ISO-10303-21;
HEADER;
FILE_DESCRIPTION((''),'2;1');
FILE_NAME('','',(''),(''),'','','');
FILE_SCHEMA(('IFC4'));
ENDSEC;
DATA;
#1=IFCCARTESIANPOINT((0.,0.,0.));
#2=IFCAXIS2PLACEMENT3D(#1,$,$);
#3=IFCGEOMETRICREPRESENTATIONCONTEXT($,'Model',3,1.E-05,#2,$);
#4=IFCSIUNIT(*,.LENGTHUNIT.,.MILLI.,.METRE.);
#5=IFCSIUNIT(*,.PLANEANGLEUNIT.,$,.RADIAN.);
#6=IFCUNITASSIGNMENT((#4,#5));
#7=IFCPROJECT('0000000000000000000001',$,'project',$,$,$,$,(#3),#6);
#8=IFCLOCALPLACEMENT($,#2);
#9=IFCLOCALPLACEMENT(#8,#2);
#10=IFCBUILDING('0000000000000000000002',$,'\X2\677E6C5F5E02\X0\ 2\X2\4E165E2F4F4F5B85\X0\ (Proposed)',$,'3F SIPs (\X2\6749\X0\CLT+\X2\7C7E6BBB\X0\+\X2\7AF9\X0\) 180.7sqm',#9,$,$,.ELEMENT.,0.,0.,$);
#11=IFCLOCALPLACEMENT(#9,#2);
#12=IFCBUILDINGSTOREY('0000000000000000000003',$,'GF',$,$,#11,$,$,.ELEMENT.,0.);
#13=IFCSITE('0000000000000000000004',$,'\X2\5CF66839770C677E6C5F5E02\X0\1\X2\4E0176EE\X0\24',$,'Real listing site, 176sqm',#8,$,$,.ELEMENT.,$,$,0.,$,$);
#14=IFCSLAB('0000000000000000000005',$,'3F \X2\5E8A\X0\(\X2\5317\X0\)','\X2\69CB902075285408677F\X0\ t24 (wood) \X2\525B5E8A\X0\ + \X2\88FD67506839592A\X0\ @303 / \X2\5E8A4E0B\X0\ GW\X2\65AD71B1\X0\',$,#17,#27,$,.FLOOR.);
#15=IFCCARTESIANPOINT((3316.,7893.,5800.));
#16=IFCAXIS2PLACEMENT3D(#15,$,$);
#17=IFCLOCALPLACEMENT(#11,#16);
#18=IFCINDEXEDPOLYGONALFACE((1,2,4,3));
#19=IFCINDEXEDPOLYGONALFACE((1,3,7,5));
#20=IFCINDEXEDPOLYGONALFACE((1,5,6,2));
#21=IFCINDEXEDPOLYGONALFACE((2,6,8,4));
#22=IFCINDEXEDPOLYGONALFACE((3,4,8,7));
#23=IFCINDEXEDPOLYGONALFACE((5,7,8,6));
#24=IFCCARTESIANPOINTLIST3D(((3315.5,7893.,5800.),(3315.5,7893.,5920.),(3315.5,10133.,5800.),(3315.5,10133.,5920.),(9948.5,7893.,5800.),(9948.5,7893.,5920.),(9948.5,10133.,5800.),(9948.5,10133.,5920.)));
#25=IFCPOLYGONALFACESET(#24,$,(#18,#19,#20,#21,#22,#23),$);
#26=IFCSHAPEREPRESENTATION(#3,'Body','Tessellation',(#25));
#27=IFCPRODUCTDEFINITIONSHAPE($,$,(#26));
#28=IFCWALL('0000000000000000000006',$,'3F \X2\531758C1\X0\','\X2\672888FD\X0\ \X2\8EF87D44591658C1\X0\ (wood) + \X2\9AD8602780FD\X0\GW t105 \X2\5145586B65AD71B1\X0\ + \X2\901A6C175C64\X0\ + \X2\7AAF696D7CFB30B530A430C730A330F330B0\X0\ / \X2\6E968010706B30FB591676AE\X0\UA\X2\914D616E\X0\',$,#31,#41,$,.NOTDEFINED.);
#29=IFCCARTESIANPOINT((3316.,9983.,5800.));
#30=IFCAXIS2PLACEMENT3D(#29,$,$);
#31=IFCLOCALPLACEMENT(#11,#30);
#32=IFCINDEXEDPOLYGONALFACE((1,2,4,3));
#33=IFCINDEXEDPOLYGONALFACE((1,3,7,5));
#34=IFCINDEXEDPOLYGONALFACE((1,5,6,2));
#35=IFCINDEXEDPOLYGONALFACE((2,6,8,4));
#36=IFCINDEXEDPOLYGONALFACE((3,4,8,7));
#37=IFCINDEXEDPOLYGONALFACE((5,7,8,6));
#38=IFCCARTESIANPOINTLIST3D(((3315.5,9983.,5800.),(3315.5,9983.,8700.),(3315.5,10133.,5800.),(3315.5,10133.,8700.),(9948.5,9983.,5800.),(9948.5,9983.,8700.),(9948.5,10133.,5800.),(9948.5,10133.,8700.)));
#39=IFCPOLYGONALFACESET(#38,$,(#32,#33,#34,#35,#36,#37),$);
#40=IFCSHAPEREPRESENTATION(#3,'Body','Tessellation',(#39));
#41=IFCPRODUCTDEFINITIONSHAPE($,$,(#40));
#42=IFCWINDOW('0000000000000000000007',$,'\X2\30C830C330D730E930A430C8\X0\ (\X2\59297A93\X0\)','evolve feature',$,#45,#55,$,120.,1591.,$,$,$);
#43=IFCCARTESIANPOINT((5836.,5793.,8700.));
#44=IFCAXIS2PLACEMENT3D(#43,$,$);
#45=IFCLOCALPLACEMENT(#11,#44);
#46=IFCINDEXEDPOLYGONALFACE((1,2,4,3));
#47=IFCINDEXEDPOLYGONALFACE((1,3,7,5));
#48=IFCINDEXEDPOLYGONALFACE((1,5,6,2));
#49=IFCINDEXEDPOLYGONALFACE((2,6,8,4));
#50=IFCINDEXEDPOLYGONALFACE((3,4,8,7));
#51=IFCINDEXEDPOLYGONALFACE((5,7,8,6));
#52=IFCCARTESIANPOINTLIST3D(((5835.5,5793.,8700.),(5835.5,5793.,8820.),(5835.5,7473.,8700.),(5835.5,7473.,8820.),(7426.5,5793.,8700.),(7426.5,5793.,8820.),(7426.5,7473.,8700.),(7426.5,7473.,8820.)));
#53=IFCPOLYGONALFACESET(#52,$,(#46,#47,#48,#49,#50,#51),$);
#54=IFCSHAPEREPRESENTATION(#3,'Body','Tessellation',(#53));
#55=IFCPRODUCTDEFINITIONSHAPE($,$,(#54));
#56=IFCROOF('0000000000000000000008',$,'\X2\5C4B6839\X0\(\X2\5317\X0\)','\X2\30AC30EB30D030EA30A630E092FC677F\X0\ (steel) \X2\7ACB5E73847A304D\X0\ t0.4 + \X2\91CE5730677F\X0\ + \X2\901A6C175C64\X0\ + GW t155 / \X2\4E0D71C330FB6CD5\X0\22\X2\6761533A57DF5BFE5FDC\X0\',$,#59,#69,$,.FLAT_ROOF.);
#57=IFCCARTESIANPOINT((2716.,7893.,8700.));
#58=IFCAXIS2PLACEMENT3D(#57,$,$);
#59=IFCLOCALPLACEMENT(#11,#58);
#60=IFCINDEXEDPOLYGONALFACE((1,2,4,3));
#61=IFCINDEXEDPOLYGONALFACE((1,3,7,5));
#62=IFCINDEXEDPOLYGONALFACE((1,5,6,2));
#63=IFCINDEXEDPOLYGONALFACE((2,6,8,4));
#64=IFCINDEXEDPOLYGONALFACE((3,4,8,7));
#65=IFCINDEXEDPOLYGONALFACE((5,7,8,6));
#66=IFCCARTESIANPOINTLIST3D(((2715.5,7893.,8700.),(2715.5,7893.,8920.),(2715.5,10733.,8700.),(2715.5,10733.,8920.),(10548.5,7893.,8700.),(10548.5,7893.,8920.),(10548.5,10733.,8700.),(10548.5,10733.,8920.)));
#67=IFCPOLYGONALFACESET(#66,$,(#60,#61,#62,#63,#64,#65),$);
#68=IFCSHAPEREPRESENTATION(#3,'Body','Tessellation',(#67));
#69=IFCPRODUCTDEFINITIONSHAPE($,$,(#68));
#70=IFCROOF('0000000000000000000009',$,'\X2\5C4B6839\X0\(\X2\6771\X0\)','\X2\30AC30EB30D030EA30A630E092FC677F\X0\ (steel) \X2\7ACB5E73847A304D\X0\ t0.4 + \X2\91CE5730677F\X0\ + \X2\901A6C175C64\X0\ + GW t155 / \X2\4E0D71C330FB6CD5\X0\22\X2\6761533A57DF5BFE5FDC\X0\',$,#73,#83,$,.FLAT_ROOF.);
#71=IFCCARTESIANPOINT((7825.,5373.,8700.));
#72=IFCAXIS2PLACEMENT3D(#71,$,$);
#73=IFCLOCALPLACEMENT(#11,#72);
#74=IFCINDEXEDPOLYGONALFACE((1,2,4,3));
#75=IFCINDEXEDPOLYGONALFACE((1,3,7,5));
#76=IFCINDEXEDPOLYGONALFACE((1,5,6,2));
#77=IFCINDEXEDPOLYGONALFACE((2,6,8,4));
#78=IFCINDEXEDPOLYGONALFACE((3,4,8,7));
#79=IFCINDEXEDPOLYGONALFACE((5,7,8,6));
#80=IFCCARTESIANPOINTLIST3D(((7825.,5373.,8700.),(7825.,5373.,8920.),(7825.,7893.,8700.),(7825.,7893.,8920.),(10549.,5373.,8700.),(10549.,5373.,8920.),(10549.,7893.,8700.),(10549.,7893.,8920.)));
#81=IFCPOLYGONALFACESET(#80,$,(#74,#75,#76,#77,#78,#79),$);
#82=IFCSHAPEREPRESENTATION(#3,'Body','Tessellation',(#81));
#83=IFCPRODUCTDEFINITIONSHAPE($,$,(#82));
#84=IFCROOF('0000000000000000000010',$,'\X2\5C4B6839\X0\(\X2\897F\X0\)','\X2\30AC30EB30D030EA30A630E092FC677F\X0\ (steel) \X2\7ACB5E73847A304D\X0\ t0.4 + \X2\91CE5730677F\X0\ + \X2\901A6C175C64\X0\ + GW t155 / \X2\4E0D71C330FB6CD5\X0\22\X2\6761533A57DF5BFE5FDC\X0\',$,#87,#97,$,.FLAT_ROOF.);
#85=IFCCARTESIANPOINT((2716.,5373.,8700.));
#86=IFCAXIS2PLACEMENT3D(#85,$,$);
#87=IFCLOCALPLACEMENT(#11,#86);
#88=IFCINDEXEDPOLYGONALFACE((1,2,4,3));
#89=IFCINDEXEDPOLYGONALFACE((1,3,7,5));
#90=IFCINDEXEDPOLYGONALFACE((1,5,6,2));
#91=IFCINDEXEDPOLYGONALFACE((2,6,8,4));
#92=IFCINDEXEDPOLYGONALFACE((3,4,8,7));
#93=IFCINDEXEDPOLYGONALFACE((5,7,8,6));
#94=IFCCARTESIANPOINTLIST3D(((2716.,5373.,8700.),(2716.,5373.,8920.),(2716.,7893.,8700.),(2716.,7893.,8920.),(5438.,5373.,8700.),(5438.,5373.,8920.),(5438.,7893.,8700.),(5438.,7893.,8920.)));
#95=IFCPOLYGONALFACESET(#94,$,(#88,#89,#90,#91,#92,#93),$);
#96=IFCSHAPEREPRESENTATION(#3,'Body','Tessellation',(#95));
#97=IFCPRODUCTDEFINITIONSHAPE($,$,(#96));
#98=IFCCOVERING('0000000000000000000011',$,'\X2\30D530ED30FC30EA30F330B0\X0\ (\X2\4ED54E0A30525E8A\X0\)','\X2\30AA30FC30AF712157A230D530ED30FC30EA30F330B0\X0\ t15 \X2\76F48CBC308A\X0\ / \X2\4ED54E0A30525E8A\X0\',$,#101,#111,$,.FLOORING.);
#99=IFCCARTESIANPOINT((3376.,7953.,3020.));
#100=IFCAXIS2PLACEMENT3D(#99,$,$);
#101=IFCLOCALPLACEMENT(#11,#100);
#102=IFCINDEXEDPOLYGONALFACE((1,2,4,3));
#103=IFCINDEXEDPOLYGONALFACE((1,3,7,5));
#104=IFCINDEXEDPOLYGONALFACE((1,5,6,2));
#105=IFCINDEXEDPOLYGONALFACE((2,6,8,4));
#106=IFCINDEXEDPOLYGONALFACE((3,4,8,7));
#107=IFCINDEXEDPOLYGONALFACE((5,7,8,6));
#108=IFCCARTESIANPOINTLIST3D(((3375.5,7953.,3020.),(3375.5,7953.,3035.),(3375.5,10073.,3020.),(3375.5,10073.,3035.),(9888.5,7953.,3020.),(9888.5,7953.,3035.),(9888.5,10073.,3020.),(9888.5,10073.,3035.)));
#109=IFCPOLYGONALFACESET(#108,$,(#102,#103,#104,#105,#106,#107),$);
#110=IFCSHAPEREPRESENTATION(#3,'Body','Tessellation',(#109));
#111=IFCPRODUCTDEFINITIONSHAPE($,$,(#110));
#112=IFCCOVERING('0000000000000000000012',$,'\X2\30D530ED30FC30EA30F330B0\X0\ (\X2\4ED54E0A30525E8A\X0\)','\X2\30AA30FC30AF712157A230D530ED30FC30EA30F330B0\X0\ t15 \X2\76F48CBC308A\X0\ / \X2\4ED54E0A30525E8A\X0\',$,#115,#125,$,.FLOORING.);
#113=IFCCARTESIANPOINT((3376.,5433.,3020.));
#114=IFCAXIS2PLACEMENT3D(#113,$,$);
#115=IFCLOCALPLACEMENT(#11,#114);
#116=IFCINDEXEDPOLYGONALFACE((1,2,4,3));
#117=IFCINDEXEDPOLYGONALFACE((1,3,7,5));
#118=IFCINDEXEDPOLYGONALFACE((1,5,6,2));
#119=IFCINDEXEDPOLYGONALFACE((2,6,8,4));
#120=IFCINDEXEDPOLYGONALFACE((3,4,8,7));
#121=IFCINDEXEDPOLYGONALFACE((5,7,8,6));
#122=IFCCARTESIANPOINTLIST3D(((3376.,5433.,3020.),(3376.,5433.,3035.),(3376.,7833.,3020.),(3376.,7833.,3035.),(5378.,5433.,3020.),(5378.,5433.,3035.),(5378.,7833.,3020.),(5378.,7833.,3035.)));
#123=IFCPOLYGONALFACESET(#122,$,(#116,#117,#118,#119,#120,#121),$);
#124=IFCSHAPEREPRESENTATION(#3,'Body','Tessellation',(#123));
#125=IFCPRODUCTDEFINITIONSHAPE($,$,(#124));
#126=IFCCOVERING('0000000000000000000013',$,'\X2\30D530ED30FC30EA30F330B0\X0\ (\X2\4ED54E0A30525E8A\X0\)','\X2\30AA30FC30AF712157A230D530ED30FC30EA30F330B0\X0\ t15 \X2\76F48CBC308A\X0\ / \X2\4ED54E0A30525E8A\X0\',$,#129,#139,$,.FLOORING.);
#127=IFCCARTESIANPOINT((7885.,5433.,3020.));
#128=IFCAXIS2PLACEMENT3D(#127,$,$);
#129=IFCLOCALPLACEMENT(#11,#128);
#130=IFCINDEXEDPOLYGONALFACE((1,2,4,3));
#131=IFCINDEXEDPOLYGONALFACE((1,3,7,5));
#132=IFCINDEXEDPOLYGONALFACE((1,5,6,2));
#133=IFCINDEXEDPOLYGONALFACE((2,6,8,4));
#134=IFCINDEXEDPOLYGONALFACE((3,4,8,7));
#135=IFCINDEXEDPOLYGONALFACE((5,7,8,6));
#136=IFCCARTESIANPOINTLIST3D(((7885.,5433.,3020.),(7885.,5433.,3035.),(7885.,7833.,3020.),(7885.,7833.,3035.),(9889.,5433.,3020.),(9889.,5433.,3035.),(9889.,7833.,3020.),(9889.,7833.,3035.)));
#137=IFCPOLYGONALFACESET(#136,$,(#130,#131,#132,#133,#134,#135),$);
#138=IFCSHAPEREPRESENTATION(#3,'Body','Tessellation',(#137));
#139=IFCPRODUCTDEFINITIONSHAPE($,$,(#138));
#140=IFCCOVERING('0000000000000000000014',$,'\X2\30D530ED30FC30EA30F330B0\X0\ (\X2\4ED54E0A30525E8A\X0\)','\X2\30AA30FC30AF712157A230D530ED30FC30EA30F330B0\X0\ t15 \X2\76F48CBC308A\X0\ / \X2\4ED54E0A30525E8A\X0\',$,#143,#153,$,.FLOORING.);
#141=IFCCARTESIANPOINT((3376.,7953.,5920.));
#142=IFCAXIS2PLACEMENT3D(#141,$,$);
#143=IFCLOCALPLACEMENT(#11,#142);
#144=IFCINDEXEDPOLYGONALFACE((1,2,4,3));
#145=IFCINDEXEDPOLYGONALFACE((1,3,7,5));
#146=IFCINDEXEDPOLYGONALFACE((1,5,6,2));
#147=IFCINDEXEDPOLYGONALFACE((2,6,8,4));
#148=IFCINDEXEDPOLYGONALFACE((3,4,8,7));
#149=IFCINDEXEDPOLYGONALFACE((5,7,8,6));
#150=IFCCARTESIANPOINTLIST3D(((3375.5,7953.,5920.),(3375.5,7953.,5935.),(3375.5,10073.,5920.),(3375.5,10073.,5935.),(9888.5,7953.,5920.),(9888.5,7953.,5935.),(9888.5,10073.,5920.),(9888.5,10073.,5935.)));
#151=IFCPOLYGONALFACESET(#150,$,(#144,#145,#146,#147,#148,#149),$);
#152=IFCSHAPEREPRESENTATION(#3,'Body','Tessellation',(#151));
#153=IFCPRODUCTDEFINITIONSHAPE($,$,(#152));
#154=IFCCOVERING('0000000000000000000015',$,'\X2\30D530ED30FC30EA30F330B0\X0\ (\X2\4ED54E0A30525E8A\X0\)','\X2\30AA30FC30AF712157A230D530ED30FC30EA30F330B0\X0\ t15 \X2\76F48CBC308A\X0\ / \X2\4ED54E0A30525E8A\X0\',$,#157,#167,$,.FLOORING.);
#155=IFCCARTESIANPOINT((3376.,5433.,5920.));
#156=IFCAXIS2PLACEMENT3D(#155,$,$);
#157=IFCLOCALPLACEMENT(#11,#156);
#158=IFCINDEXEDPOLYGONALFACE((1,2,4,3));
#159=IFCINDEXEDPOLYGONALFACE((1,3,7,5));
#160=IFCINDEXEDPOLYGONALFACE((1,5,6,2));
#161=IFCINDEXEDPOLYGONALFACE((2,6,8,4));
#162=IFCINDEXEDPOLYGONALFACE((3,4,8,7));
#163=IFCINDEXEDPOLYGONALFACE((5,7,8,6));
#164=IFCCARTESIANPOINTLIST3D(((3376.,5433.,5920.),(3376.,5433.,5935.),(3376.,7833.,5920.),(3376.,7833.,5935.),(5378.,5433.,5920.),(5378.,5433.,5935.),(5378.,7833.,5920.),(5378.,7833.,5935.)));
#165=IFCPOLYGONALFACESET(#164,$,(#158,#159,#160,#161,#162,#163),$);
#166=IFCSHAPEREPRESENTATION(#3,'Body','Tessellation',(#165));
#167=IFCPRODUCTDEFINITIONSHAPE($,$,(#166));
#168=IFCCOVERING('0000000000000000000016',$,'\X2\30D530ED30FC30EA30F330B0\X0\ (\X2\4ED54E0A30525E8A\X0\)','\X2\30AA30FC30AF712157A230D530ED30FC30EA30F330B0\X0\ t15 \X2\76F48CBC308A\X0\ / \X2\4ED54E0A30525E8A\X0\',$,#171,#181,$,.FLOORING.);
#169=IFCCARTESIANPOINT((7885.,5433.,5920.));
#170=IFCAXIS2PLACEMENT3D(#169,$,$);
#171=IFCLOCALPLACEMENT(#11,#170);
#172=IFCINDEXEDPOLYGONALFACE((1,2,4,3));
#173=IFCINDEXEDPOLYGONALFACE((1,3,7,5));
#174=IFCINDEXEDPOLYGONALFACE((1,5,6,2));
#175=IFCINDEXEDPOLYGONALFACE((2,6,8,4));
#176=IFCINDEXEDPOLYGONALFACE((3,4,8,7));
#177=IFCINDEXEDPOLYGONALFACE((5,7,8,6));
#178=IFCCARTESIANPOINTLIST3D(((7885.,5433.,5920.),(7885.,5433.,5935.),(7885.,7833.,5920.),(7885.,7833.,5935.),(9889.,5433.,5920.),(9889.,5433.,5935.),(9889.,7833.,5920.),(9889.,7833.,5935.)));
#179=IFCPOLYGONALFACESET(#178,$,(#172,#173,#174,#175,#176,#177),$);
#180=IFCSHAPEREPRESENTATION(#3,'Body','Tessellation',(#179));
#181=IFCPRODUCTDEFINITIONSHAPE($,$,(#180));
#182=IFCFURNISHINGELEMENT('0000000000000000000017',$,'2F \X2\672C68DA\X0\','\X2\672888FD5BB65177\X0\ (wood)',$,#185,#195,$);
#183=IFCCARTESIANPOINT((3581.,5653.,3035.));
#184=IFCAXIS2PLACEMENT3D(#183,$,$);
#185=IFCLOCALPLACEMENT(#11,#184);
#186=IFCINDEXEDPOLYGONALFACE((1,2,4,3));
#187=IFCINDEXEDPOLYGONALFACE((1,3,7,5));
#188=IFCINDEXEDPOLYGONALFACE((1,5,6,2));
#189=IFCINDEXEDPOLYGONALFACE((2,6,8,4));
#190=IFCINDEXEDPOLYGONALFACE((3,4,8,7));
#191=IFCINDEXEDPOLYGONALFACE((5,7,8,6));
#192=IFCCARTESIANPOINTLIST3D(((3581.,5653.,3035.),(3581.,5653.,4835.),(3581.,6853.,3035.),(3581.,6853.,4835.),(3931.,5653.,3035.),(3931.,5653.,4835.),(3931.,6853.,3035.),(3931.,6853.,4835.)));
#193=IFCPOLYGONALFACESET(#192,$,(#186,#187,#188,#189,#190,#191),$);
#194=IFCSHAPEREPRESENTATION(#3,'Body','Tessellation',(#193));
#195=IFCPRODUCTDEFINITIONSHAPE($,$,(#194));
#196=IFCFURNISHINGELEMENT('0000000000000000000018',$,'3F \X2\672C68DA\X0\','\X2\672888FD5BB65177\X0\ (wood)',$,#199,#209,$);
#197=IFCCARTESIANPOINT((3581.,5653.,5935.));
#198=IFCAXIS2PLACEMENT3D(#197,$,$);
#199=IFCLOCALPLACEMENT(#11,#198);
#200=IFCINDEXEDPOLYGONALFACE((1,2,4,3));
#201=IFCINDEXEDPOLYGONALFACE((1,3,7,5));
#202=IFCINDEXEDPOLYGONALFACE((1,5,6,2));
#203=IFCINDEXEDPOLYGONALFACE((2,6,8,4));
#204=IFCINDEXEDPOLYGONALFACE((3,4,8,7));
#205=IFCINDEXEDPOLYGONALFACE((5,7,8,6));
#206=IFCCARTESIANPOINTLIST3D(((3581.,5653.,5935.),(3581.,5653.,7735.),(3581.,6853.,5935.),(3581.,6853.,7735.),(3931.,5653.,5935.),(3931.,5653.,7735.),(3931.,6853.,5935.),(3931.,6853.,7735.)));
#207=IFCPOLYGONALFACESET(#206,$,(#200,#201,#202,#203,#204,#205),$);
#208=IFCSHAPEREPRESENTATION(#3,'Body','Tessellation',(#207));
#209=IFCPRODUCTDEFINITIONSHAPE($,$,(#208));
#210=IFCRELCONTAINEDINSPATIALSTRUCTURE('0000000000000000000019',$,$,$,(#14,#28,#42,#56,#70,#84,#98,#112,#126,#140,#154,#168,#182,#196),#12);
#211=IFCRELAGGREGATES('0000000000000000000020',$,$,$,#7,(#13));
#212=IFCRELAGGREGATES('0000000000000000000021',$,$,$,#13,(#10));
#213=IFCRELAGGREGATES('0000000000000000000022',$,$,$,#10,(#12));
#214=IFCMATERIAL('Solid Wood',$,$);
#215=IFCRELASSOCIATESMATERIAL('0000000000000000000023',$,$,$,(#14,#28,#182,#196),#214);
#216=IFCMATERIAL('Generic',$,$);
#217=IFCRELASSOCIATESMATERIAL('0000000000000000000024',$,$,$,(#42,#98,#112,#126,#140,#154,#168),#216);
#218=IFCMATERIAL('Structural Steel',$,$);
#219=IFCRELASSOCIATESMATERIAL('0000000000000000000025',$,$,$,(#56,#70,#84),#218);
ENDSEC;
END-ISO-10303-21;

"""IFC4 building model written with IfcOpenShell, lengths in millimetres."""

from ifc_helpers import new_model, si_unit, frame, frame_2d, origin, place, context, project, spatial, rectangle, extrude, material, element, save


model = new_model("IFC4")

# Units and contexts
model_context = context("Model", 3, precision=1e-05, world=origin())
ifc_project = project(units=[si_unit("LENGTHUNIT", "METRE", prefix="MILLI"), si_unit("PLANEANGLEUNIT", "RADIAN")], contexts=[model_context])

# Site, building, storey
site_placement = place(None, origin())
site = spatial("IfcSite", under=ifc_project, at=site_placement, Name="島根県松江市1丁目24", ObjectType="Real listing site, 176sqm", CompositionType="ELEMENT", RefElevation=0.0)
building_placement = place(site_placement, origin())
building = spatial("IfcBuilding", under=site, at=building_placement, Name="松江市 2世帯住宅 (Proposed)", ObjectType="3F SIPs (杉CLT+籾殻+竹) 180.7sqm", CompositionType="ELEMENT", ElevationOfRefHeight=0.0, ElevationOfTerrain=0.0)
storey_placement = place(building_placement, origin())
storey = spatial("IfcBuildingStorey", under=building, at=storey_placement, Name="GF", CompositionType="ELEMENT", Elevation=0.0)

# Slab
ifc_material_1 = material(Name="Solid Wood")
slab_placement = place(storey_placement, frame((3316.0, 7893.0, 5800.0)))
element("IfcSlab", 1, at=slab_placement, inside=storey, material=ifc_material_1, Name="3F 床(北)", Description="構造用合板 t24 (wood) 剛床 + 製材根太 @303 / 床下 GW断熱", PredefinedType="FLOOR", context=model_context, shape_type="SweptSolid", body=[
    extrude(rectangle(XDim=6633.0, YDim=2240.0, at=frame_2d((3316.0, 1120.0))), frame((3316.0, 7893.0, 5800.0)), (0.0, 0.0, 1.0), 120.0),
])

# Wall
wall_1_placement = place(storey_placement, frame((3316.0, 9983.0, 5800.0)))
element("IfcWall", 2, at=wall_1_placement, inside=storey, material=ifc_material_1, Name="3F 北壁", Description="木製 軸組外壁 (wood) + 高性能GW t105 充填断熱 + 通気層 + 窯業系サイディング / 準耐火・外皮UA配慮", PredefinedType="NOTDEFINED", context=model_context, shape_type="SweptSolid", body=[
    extrude(rectangle(XDim=6633.0, YDim=150.0, at=frame_2d((3316.0, 75.0))), frame((3316.0, 9983.0, 5800.0)), (0.0, 0.0, 1.0), 2900.0),
])

# Window
ifc_material_2 = material(Name="Generic")
window_1_placement = place(storey_placement, frame((5836.0, 5793.0, 8700.0)))
element("IfcWindow", 3, at=window_1_placement, inside=storey, material=ifc_material_2, Name="トップライト (天窓)", Description="evolve feature", OverallHeight=120.0, OverallWidth=1591.0, context=model_context, shape_type="SweptSolid", body=[
    extrude(rectangle(XDim=1591.0, YDim=1680.0, at=frame_2d((795.0, 840.0))), frame((5836.0, 5793.0, 8700.0)), (0.0, 0.0, 1.0), 120.0),
])

# Roofs
ifc_material_3 = material(Name="Structural Steel")
roof_1_placement = place(storey_placement, frame((2716.0, 7893.0, 8700.0)))
element("IfcRoof", 4, at=roof_1_placement, inside=storey, material=ifc_material_3, Name="屋根(北)", Description="ガルバリウム鋼板 (steel) 立平葺き t0.4 + 野地板 + 通気層 + GW t155 / 不燃・法22条区域対応", PredefinedType="FLAT_ROOF", context=model_context, shape_type="SweptSolid", body=[
    extrude(rectangle(XDim=7833.0, YDim=2840.0, at=frame_2d((3916.0, 1420.0))), frame((2716.0, 7893.0, 8700.0)), (0.0, 0.0, 1.0), 220.0),
])
roof_2_placement = place(storey_placement, frame((7825.0, 5373.0, 8700.0)))
element("IfcRoof", 5, at=roof_2_placement, inside=storey, material=ifc_material_3, Name="屋根(東)", Description="ガルバリウム鋼板 (steel) 立平葺き t0.4 + 野地板 + 通気層 + GW t155 / 不燃・法22条区域対応", PredefinedType="FLAT_ROOF", context=model_context, shape_type="SweptSolid", body=[
    extrude(rectangle(XDim=2724.0, YDim=2520.0, at=frame_2d((1362.0, 1260.0))), frame((7825.0, 5373.0, 8700.0)), (0.0, 0.0, 1.0), 220.0),
])
roof_3_placement = place(storey_placement, frame((2716.0, 5373.0, 8700.0)))
element("IfcRoof", 6, at=roof_3_placement, inside=storey, material=ifc_material_3, Name="屋根(西)", Description="ガルバリウム鋼板 (steel) 立平葺き t0.4 + 野地板 + 通気層 + GW t155 / 不燃・法22条区域対応", PredefinedType="FLAT_ROOF", context=model_context, shape_type="SweptSolid", body=[
    extrude(rectangle(XDim=2722.0, YDim=2520.0, at=frame_2d((1361.0, 1260.0))), frame((2716.0, 5373.0, 8700.0)), (0.0, 0.0, 1.0), 220.0),
])

# Coverings
covering_1_placement = place(storey_placement, frame((3376.0, 7953.0, 3020.0)))
element("IfcCovering", 7, at=covering_1_placement, inside=storey, material=ifc_material_2, Name="フローリング (仕上げ床)", Description="オーク無垢フローリング t15 直貼り / 仕上げ床", PredefinedType="FLOORING", context=model_context, shape_type="SweptSolid", body=[
    extrude(rectangle(XDim=6513.0, YDim=2120.0, at=frame_2d((3256.0, 1060.0))), frame((3376.0, 7953.0, 3020.0)), (0.0, 0.0, 1.0), 15.0),
])
covering_2_placement = place(storey_placement, frame((3376.0, 5433.0, 3020.0)))
element("IfcCovering", 8, at=covering_2_placement, inside=storey, material=ifc_material_2, Name="フローリング (仕上げ床)", Description="オーク無垢フローリング t15 直貼り / 仕上げ床", PredefinedType="FLOORING", context=model_context, shape_type="SweptSolid", body=[
    extrude(rectangle(XDim=2002.0, YDim=2400.0, at=frame_2d((1001.0, 1200.0))), frame((3376.0, 5433.0, 3020.0)), (0.0, 0.0, 1.0), 15.0),
])
covering_3_placement = place(storey_placement, frame((7885.0, 5433.0, 3020.0)))
element("IfcCovering", 9, at=covering_3_placement, inside=storey, material=ifc_material_2, Name="フローリング (仕上げ床)", Description="オーク無垢フローリング t15 直貼り / 仕上げ床", PredefinedType="FLOORING", context=model_context, shape_type="SweptSolid", body=[
    extrude(rectangle(XDim=2004.0, YDim=2400.0, at=frame_2d((1002.0, 1200.0))), frame((7885.0, 5433.0, 3020.0)), (0.0, 0.0, 1.0), 15.0),
])
covering_4_placement = place(storey_placement, frame((3376.0, 7953.0, 5920.0)))
element("IfcCovering", 10, at=covering_4_placement, inside=storey, material=ifc_material_2, Name="フローリング (仕上げ床)", Description="オーク無垢フローリング t15 直貼り / 仕上げ床", PredefinedType="FLOORING", context=model_context, shape_type="SweptSolid", body=[
    extrude(rectangle(XDim=6513.0, YDim=2120.0, at=frame_2d((3256.0, 1060.0))), frame((3376.0, 7953.0, 5920.0)), (0.0, 0.0, 1.0), 15.0),
])
covering_5_placement = place(storey_placement, frame((3376.0, 5433.0, 5920.0)))
element("IfcCovering", 11, at=covering_5_placement, inside=storey, material=ifc_material_2, Name="フローリング (仕上げ床)", Description="オーク無垢フローリング t15 直貼り / 仕上げ床", PredefinedType="FLOORING", context=model_context, shape_type="SweptSolid", body=[
    extrude(rectangle(XDim=2002.0, YDim=2400.0, at=frame_2d((1001.0, 1200.0))), frame((3376.0, 5433.0, 5920.0)), (0.0, 0.0, 1.0), 15.0),
])
covering_6_placement = place(storey_placement, frame((7885.0, 5433.0, 5920.0)))
element("IfcCovering", 12, at=covering_6_placement, inside=storey, material=ifc_material_2, Name="フローリング (仕上げ床)", Description="オーク無垢フローリング t15 直貼り / 仕上げ床", PredefinedType="FLOORING", context=model_context, shape_type="SweptSolid", body=[
    extrude(rectangle(XDim=2004.0, YDim=2400.0, at=frame_2d((1002.0, 1200.0))), frame((7885.0, 5433.0, 5920.0)), (0.0, 0.0, 1.0), 15.0),
])

# Furnishing elements
furnishing_1_placement = place(storey_placement, frame((3581.0, 5653.0, 3035.0)))
element("IfcFurnishingElement", 13, at=furnishing_1_placement, inside=storey, material=ifc_material_1, Name="2F 本棚", Description="木製家具 (wood)", context=model_context, shape_type="SweptSolid", body=[
    extrude(rectangle(XDim=350.0, YDim=1200.0, at=frame_2d((175.0, 600.0))), frame((3581.0, 5653.0, 3035.0)), (0.0, 0.0, 1.0), 1800.0),
])
furnishing_2_placement = place(storey_placement, frame((3581.0, 5653.0, 5935.0)))
element("IfcFurnishingElement", 14, at=furnishing_2_placement, inside=storey, material=ifc_material_1, Name="3F 本棚", Description="木製家具 (wood)", context=model_context, shape_type="SweptSolid", body=[
    extrude(rectangle(XDim=350.0, YDim=1200.0, at=frame_2d((175.0, 600.0))), frame((3581.0, 5653.0, 5935.0)), (0.0, 0.0, 1.0), 1800.0),
])

save(model, "model.ifc")
